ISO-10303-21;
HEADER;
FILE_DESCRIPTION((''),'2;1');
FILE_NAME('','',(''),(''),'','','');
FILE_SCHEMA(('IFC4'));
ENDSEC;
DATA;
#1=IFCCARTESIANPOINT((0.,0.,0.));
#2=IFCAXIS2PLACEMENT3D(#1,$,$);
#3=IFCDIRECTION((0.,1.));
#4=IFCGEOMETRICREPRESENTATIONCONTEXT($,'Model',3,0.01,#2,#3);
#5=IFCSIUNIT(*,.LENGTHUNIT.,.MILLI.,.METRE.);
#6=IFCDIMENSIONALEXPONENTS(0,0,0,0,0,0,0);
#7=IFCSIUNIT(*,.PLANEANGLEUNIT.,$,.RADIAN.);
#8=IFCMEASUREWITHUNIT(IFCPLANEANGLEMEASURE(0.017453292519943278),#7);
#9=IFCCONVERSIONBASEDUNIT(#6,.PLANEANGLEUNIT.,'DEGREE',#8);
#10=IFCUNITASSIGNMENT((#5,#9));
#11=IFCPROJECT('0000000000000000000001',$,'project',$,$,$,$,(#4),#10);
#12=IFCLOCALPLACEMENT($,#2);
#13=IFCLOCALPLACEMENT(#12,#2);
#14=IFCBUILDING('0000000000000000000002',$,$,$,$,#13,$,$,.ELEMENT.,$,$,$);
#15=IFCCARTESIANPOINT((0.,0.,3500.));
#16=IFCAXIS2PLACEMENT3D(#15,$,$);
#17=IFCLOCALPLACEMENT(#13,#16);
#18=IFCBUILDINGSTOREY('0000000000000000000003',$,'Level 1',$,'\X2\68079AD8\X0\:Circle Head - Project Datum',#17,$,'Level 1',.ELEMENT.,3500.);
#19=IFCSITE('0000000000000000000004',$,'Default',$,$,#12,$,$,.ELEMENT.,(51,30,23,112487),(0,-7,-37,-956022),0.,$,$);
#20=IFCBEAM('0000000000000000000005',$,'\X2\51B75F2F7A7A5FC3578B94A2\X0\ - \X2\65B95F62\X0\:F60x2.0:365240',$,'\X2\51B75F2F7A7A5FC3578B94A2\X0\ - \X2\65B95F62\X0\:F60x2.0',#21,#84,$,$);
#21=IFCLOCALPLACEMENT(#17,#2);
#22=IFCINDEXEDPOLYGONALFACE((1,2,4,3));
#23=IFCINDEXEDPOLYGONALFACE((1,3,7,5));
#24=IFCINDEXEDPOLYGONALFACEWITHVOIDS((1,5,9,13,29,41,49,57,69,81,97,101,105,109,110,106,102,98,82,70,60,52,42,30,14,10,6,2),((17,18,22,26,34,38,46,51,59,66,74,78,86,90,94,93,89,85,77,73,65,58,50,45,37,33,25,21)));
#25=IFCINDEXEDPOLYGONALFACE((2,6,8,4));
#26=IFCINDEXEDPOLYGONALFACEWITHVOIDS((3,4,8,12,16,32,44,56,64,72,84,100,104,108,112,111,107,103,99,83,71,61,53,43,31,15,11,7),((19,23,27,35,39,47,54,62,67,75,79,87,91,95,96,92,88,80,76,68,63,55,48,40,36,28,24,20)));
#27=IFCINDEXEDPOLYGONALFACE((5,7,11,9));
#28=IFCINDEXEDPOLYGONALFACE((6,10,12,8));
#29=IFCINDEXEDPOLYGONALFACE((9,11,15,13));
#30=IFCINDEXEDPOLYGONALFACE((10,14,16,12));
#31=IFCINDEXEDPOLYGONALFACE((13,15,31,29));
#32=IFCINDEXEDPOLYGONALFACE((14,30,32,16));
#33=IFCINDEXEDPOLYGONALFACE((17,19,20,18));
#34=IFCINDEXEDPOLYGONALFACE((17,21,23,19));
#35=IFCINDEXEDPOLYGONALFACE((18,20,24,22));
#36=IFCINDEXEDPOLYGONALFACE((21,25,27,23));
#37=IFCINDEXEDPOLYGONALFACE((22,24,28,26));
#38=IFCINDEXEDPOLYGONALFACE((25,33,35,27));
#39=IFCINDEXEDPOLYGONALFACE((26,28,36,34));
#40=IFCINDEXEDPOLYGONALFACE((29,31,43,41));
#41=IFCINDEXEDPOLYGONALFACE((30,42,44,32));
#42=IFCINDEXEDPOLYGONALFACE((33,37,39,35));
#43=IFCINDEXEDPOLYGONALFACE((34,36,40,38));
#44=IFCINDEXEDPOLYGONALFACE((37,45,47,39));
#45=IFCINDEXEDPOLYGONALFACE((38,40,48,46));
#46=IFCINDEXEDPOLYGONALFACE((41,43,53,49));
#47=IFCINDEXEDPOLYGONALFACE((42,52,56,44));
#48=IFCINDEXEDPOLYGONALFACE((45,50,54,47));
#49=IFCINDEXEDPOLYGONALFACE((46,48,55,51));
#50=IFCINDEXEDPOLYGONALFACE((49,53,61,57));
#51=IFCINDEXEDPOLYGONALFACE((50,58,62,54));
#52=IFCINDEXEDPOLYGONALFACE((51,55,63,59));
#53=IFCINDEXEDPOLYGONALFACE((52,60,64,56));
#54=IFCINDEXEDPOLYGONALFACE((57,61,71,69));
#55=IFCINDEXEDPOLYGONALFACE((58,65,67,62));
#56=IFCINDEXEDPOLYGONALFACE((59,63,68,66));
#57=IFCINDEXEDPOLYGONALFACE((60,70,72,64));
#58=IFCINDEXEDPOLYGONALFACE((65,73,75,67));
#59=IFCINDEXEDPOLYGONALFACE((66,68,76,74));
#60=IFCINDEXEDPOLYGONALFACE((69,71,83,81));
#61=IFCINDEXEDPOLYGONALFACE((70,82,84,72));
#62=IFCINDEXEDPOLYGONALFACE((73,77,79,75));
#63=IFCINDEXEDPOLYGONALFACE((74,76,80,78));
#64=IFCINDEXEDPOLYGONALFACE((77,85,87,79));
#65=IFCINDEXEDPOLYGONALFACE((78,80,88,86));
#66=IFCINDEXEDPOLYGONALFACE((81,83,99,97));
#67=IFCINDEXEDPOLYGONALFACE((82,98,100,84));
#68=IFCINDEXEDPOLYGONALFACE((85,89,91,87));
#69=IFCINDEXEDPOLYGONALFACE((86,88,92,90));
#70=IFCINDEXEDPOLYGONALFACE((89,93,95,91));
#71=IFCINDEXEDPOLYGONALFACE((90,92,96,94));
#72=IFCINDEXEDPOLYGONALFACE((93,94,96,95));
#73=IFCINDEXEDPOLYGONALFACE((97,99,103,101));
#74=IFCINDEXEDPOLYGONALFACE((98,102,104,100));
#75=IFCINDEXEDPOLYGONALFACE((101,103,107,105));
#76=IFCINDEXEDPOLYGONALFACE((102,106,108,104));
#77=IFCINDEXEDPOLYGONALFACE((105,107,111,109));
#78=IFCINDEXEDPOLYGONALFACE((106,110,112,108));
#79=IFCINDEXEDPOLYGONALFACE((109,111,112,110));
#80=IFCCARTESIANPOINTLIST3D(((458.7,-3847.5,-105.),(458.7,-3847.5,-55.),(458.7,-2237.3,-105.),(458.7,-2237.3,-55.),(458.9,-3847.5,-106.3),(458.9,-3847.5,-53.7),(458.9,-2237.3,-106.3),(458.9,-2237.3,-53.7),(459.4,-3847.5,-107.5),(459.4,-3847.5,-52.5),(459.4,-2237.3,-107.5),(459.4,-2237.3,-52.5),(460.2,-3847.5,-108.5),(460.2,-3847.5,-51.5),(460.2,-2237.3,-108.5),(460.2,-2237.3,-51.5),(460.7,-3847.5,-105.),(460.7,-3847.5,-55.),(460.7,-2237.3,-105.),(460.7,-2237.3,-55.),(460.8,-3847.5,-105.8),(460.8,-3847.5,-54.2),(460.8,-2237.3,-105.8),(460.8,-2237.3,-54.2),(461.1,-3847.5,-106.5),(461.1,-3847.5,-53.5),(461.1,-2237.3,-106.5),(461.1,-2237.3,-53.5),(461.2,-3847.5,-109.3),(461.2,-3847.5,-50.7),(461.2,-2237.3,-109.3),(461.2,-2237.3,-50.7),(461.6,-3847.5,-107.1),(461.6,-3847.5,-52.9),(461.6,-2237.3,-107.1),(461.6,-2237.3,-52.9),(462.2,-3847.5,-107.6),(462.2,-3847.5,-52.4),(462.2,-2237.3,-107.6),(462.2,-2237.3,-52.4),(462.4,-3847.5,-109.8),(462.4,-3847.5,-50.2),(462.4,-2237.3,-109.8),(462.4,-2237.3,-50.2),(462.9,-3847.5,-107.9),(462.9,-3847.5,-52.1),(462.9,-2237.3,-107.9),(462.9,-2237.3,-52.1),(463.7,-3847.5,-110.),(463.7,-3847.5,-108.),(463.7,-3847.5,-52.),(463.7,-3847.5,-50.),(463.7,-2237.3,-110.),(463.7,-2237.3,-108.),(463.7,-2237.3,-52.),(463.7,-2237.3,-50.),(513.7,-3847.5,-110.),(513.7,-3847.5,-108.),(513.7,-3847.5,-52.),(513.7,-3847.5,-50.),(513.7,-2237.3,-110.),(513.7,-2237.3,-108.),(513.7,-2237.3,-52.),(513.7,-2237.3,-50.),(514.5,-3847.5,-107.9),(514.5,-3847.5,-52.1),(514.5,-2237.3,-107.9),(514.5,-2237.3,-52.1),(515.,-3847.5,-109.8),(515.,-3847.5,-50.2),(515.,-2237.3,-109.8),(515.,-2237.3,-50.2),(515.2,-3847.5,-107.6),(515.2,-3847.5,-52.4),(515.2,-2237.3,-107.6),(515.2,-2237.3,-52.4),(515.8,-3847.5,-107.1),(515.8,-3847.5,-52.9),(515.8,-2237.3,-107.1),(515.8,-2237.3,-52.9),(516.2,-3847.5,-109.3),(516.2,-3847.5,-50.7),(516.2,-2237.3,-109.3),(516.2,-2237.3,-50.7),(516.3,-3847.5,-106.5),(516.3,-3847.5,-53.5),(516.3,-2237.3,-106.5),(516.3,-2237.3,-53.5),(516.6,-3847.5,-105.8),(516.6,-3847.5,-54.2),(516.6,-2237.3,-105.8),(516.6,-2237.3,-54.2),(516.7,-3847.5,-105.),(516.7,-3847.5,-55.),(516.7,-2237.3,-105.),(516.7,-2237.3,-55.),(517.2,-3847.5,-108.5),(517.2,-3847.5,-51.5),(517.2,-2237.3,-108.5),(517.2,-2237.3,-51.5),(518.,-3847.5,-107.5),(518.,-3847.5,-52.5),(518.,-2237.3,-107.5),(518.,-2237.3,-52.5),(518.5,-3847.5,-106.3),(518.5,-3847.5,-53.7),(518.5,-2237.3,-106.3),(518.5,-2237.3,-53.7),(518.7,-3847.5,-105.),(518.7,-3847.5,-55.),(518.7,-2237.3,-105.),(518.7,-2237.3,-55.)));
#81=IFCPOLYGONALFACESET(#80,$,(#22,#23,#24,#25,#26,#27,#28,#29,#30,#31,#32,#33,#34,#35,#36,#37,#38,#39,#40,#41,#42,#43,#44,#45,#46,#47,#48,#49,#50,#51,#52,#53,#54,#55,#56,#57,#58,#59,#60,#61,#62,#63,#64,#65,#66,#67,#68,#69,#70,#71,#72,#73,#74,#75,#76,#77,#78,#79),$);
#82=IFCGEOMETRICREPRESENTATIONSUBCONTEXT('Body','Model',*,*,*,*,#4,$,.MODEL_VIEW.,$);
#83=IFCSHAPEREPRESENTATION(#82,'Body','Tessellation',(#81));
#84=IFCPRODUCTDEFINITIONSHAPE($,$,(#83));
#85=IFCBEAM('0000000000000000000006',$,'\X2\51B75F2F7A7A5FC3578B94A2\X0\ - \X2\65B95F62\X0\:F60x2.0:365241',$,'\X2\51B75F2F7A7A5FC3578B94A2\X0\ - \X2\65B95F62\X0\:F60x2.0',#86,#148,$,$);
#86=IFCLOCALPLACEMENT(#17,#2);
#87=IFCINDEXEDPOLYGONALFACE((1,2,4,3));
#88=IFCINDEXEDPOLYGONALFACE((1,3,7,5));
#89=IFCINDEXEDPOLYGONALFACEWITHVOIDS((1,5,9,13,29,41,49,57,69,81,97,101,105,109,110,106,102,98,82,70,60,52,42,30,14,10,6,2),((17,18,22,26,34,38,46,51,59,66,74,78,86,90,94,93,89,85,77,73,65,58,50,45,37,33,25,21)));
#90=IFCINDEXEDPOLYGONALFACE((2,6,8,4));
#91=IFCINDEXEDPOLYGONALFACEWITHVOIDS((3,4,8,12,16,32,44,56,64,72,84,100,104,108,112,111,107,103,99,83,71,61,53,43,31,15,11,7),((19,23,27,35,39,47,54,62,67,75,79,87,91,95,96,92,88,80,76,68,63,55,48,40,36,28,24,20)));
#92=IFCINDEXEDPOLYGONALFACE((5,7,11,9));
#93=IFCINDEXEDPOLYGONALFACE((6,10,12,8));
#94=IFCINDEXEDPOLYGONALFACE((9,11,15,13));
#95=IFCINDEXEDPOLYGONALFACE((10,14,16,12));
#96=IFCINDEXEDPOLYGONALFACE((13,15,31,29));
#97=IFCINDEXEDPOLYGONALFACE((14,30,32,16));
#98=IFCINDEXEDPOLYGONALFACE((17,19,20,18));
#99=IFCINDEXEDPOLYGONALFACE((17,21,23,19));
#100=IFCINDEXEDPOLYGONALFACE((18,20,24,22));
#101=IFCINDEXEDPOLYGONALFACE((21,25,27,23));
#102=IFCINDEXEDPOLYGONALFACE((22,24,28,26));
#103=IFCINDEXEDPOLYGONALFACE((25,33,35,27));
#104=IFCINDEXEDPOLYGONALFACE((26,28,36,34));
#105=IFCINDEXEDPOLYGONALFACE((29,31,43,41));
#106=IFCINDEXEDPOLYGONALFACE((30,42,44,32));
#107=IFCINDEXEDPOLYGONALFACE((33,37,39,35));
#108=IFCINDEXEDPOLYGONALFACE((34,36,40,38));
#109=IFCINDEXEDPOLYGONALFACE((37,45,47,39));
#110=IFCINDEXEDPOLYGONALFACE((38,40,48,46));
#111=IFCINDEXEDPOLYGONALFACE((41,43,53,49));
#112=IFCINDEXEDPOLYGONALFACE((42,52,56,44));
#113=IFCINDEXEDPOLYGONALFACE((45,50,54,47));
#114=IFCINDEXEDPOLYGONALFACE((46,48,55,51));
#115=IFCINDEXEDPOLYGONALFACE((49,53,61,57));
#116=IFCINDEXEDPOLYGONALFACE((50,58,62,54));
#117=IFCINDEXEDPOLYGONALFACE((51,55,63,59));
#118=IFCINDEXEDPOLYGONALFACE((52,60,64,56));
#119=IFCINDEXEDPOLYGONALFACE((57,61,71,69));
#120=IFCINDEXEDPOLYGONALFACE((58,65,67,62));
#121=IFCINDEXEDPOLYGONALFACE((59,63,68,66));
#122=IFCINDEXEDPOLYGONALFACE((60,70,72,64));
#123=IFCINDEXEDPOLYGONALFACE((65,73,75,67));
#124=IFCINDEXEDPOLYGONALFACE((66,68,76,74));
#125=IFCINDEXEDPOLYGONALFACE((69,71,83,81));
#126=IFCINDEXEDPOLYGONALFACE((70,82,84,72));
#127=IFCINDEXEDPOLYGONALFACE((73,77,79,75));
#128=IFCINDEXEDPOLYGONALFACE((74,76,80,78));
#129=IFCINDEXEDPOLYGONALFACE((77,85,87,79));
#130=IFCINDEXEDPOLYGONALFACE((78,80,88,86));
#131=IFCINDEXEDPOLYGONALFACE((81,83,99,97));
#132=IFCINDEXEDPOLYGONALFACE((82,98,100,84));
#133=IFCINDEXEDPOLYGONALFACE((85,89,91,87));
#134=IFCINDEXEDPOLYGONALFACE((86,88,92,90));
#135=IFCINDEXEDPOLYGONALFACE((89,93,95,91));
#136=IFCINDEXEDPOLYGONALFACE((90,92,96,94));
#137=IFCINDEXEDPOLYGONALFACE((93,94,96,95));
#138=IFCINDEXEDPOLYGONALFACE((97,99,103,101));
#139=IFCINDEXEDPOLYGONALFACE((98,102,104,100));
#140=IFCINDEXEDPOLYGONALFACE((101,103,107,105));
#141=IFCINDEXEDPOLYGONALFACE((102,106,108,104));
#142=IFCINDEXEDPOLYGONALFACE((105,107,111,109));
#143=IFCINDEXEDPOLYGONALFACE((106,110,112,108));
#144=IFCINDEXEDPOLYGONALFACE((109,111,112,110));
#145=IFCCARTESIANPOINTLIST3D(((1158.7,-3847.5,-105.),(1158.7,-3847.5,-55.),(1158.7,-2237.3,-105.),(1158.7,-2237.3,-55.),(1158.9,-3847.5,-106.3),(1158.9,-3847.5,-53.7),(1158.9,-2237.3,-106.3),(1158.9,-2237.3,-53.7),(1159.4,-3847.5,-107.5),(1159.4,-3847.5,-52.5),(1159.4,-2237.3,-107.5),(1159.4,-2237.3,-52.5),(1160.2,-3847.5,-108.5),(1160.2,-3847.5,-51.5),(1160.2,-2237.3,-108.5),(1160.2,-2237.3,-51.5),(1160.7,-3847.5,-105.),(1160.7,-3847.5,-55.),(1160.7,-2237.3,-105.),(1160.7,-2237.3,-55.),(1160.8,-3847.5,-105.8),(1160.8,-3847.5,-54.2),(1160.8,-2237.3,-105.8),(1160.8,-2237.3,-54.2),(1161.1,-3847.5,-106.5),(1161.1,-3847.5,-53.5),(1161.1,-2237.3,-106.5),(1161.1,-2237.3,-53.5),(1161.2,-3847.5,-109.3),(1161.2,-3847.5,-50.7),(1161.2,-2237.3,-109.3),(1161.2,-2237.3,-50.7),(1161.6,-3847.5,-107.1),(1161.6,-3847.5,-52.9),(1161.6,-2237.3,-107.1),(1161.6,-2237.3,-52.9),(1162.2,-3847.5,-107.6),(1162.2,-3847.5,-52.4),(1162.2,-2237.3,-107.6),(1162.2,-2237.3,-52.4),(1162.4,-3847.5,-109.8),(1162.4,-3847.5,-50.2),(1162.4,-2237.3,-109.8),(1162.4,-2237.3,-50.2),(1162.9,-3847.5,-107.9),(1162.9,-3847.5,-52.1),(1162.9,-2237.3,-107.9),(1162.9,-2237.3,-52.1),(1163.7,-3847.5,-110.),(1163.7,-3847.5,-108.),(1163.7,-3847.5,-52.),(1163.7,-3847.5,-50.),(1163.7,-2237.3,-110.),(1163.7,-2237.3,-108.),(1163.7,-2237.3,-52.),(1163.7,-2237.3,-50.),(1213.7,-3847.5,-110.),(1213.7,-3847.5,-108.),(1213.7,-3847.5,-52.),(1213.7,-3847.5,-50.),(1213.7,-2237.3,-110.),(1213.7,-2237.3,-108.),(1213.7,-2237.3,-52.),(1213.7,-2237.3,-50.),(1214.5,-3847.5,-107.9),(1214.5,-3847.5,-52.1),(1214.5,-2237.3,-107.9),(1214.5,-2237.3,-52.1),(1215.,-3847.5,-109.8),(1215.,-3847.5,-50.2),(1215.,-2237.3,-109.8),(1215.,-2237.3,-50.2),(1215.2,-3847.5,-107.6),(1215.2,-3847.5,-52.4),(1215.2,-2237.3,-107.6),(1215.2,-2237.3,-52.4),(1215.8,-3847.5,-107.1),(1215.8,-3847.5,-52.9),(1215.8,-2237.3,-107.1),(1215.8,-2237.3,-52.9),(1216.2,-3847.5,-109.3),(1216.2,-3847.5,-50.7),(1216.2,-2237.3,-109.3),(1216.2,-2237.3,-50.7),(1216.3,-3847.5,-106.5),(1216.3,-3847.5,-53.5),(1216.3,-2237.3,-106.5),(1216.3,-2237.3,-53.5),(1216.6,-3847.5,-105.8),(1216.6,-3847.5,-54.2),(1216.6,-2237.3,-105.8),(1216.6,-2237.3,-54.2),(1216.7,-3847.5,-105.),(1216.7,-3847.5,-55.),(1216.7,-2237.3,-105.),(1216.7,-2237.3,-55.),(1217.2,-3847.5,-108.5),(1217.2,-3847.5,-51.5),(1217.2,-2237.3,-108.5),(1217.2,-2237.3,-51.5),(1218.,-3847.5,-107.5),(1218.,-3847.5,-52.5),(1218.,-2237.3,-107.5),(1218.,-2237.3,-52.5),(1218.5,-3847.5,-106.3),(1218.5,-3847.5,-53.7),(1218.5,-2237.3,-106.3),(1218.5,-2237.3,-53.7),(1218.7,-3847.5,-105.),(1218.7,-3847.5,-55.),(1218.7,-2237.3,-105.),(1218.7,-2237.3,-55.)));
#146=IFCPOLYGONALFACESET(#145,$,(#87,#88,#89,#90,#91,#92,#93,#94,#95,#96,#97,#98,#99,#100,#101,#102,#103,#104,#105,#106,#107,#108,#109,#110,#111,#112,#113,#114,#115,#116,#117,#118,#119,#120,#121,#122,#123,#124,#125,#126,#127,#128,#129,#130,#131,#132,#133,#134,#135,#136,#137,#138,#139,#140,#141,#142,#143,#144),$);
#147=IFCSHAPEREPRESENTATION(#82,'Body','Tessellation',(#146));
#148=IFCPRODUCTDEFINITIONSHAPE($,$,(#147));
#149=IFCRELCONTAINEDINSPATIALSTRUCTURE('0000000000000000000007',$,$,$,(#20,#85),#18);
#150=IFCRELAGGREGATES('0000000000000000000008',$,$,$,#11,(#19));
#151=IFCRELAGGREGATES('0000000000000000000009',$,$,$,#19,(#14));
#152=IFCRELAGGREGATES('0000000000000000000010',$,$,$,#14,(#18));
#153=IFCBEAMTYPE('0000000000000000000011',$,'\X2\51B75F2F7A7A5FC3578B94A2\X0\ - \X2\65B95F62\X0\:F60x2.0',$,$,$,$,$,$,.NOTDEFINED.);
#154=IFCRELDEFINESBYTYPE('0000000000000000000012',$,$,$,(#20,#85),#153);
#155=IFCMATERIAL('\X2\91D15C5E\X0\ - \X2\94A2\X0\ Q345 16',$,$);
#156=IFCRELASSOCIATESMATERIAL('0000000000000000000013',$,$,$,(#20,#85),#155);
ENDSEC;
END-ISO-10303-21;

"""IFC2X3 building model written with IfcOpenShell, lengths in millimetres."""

from ifc_helpers import new_model, entity, si_unit, converted_unit, direction, frame, frame_2d, origin, place, context, subcontext, project, spatial, polyline, circle_curve, parameter, trimmed, segment, composite_curve, outline, extrude, material, type_object, element, save


model = new_model("IFC2X3")

# Units and contexts
model_context = context("Model", 3, precision=0.01, world=origin(), true_north=direction((0.0, 1.0)))
body_context = subcontext(model_context, "Body", "Model", "MODEL_VIEW")
ifc_project = project(units=[si_unit("LENGTHUNIT", "METRE", prefix="MILLI"), converted_unit("PLANEANGLEUNIT", "DEGREE", entity("IfcPlaneAngleMeasure", 0.017453292519943278), si_unit("PLANEANGLEUNIT", "RADIAN"), dimensions=[0, 0, 0, 0, 0, 0, 0])], contexts=[model_context])

# Site, building, storey
site_placement = place(None, origin())
site = spatial("IfcSite", under=ifc_project, at=site_placement, Name="Default", CompositionType="ELEMENT", RefLatitude=(51, 30, 23, 112487), RefLongitude=(0, -7, -37, -956022), RefElevation=0.0)
building_placement = place(site_placement, origin())
building = spatial("IfcBuilding", under=site, at=building_placement, CompositionType="ELEMENT")
storey_placement = place(building_placement, frame((0.0, 0.0, 3500.0)))
storey = spatial("IfcBuildingStorey", under=building, at=storey_placement, Name="Level 1", ObjectType="标高:Circle Head - Project Datum", LongName="Level 1", CompositionType="ELEMENT", Elevation=3500.0)

# Beams
ifc_material_1 = material(Name="金属 - 钢 Q345 16")
beam_type_1 = type_object("IfcBeamType", Name="冷弯空心型钢 - 方形:F60x2.0", PredefinedType="NOTDEFINED")
beam_1_placement = place(storey_placement, frame((488.7, -3815.6, -50.0), z_axis=(0.0, 0.0, 1.0), x_axis=(0.0, 1.0, 0.0)))
element("IfcBeam", 1, at=beam_1_placement, inside=storey, type_object=beam_type_1, material=ifc_material_1, Name="冷弯空心型钢 - 方形:F60x2.0:365240", ObjectType="冷弯空心型钢 - 方形:F60x2.0", context=body_context, shape_type="SweptSolid", body=[
    extrude(outline(composite_curve([segment(polyline([(-25.0, -30.0), (25.0, -30.0)]), True, "CONTINUOUS"), segment(trimmed(circle_curve(frame_2d((25.0, -25.0), x_axis=(1.0, 0.0)), 5.0), [parameter(270.0)], [parameter(360.0)], True, "PARAMETER"), True, "CONTINUOUS"), segment(polyline([(30.0, -25.0), (30.0, 25.0)]), True, "CONTINUOUS"), segment(trimmed(circle_curve(frame_2d((25.0, 25.0), x_axis=(1.0, 0.0)), 5.0), [parameter(360.0)], [parameter(90.0)], True, "PARAMETER"), True, "CONTINUOUS"), segment(polyline([(25.0, 30.0), (-25.0, 30.0)]), True, "CONTINUOUS"), segment(trimmed(circle_curve(frame_2d((-25.0, 25.0), x_axis=(1.0, 0.0)), 5.0), [parameter(90.0)], [parameter(180.0)], True, "PARAMETER"), True, "CONTINUOUS"), segment(polyline([(-30.0, 25.0), (-30.0, -25.0)]), True, "CONTINUOUS"), segment(trimmed(circle_curve(frame_2d((-25.0, -25.0), x_axis=(1.0, 0.0)), 5.0), [parameter(180.0)], [parameter(270.0)], True, "PARAMETER"), True, "CONTINUOUS")], self_intersect=False), holes=[composite_curve([segment(trimmed(circle_curve(frame_2d((-25.0, -25.0), x_axis=(1.0, 0.0)), 3.0), [parameter(180.0)], [parameter(270.0)], True, "PARAMETER"), False, "CONTINUOUS"), segment(polyline([(-28.0, -25.0), (-28.0, 25.0)]), True, "CONTINUOUS"), segment(trimmed(circle_curve(frame_2d((-25.0, 25.0), x_axis=(1.0, 0.0)), 3.0), [parameter(90.0)], [parameter(180.0)], True, "PARAMETER"), False, "CONTINUOUS"), segment(polyline([(-25.0, 28.0), (25.0, 28.0)]), True, "CONTINUOUS"), segment(trimmed(circle_curve(frame_2d((25.0, 25.0), x_axis=(1.0, 0.0)), 3.0), [parameter(0.0)], [parameter(90.0)], True, "PARAMETER"), False, "CONTINUOUS"), segment(polyline([(28.0, 25.0), (28.0, -25.0)]), True, "CONTINUOUS"), segment(trimmed(circle_curve(frame_2d((25.0, -25.0), x_axis=(1.0, 0.0)), 3.0), [parameter(270.0)], [parameter(360.0)], True, "PARAMETER"), False, "CONTINUOUS"), segment(polyline([(25.0, -28.0), (-25.0, -28.0)]), True, "CONTINUOUS")], self_intersect=False)]), frame((-31.9, 0.0, -30.0), z_axis=(1.0, 0.0, 0.0), x_axis=(0.0, -1.0, 0.0)), (0.0, 0.0, 1.0), 1610.2),
])
beam_2_placement = place(storey_placement, frame((1188.7, -3815.6, -50.0), z_axis=(0.0, 0.0, 1.0), x_axis=(0.0, 1.0, 0.0)))
element("IfcBeam", 2, at=beam_2_placement, inside=storey, type_object=beam_type_1, material=ifc_material_1, Name="冷弯空心型钢 - 方形:F60x2.0:365241", ObjectType="冷弯空心型钢 - 方形:F60x2.0", context=body_context, shape_type="SweptSolid", body=[
    extrude(outline(composite_curve([segment(polyline([(-25.0, -30.0), (25.0, -30.0)]), True, "CONTINUOUS"), segment(trimmed(circle_curve(frame_2d((25.0, -25.0), x_axis=(1.0, 0.0)), 5.0), [parameter(270.0)], [parameter(360.0)], True, "PARAMETER"), True, "CONTINUOUS"), segment(polyline([(30.0, -25.0), (30.0, 25.0)]), True, "CONTINUOUS"), segment(trimmed(circle_curve(frame_2d((25.0, 25.0), x_axis=(1.0, 0.0)), 5.0), [parameter(360.0)], [parameter(90.0)], True, "PARAMETER"), True, "CONTINUOUS"), segment(polyline([(25.0, 30.0), (-25.0, 30.0)]), True, "CONTINUOUS"), segment(trimmed(circle_curve(frame_2d((-25.0, 25.0), x_axis=(1.0, 0.0)), 5.0), [parameter(90.0)], [parameter(180.0)], True, "PARAMETER"), True, "CONTINUOUS"), segment(polyline([(-30.0, 25.0), (-30.0, -25.0)]), True, "CONTINUOUS"), segment(trimmed(circle_curve(frame_2d((-25.0, -25.0), x_axis=(1.0, 0.0)), 5.0), [parameter(180.0)], [parameter(270.0)], True, "PARAMETER"), True, "CONTINUOUS")], self_intersect=False), holes=[composite_curve([segment(trimmed(circle_curve(frame_2d((-25.0, -25.0), x_axis=(1.0, 0.0)), 3.0), [parameter(180.0)], [parameter(270.0)], True, "PARAMETER"), False, "CONTINUOUS"), segment(polyline([(-28.0, -25.0), (-28.0, 25.0)]), True, "CONTINUOUS"), segment(trimmed(circle_curve(frame_2d((-25.0, 25.0), x_axis=(1.0, 0.0)), 3.0), [parameter(90.0)], [parameter(180.0)], True, "PARAMETER"), False, "CONTINUOUS"), segment(polyline([(-25.0, 28.0), (25.0, 28.0)]), True, "CONTINUOUS"), segment(trimmed(circle_curve(frame_2d((25.0, 25.0), x_axis=(1.0, 0.0)), 3.0), [parameter(0.0)], [parameter(90.0)], True, "PARAMETER"), False, "CONTINUOUS"), segment(polyline([(28.0, 25.0), (28.0, -25.0)]), True, "CONTINUOUS"), segment(trimmed(circle_curve(frame_2d((25.0, -25.0), x_axis=(1.0, 0.0)), 3.0), [parameter(270.0)], [parameter(360.0)], True, "PARAMETER"), False, "CONTINUOUS"), segment(polyline([(25.0, -28.0), (-25.0, -28.0)]), True, "CONTINUOUS")], self_intersect=False)]), frame((-31.9, 0.0, -30.0), z_axis=(1.0, 0.0, 0.0), x_axis=(0.0, -1.0, 0.0)), (0.0, 0.0, 1.0), 1610.2),
])

save(model, "model.ifc")
